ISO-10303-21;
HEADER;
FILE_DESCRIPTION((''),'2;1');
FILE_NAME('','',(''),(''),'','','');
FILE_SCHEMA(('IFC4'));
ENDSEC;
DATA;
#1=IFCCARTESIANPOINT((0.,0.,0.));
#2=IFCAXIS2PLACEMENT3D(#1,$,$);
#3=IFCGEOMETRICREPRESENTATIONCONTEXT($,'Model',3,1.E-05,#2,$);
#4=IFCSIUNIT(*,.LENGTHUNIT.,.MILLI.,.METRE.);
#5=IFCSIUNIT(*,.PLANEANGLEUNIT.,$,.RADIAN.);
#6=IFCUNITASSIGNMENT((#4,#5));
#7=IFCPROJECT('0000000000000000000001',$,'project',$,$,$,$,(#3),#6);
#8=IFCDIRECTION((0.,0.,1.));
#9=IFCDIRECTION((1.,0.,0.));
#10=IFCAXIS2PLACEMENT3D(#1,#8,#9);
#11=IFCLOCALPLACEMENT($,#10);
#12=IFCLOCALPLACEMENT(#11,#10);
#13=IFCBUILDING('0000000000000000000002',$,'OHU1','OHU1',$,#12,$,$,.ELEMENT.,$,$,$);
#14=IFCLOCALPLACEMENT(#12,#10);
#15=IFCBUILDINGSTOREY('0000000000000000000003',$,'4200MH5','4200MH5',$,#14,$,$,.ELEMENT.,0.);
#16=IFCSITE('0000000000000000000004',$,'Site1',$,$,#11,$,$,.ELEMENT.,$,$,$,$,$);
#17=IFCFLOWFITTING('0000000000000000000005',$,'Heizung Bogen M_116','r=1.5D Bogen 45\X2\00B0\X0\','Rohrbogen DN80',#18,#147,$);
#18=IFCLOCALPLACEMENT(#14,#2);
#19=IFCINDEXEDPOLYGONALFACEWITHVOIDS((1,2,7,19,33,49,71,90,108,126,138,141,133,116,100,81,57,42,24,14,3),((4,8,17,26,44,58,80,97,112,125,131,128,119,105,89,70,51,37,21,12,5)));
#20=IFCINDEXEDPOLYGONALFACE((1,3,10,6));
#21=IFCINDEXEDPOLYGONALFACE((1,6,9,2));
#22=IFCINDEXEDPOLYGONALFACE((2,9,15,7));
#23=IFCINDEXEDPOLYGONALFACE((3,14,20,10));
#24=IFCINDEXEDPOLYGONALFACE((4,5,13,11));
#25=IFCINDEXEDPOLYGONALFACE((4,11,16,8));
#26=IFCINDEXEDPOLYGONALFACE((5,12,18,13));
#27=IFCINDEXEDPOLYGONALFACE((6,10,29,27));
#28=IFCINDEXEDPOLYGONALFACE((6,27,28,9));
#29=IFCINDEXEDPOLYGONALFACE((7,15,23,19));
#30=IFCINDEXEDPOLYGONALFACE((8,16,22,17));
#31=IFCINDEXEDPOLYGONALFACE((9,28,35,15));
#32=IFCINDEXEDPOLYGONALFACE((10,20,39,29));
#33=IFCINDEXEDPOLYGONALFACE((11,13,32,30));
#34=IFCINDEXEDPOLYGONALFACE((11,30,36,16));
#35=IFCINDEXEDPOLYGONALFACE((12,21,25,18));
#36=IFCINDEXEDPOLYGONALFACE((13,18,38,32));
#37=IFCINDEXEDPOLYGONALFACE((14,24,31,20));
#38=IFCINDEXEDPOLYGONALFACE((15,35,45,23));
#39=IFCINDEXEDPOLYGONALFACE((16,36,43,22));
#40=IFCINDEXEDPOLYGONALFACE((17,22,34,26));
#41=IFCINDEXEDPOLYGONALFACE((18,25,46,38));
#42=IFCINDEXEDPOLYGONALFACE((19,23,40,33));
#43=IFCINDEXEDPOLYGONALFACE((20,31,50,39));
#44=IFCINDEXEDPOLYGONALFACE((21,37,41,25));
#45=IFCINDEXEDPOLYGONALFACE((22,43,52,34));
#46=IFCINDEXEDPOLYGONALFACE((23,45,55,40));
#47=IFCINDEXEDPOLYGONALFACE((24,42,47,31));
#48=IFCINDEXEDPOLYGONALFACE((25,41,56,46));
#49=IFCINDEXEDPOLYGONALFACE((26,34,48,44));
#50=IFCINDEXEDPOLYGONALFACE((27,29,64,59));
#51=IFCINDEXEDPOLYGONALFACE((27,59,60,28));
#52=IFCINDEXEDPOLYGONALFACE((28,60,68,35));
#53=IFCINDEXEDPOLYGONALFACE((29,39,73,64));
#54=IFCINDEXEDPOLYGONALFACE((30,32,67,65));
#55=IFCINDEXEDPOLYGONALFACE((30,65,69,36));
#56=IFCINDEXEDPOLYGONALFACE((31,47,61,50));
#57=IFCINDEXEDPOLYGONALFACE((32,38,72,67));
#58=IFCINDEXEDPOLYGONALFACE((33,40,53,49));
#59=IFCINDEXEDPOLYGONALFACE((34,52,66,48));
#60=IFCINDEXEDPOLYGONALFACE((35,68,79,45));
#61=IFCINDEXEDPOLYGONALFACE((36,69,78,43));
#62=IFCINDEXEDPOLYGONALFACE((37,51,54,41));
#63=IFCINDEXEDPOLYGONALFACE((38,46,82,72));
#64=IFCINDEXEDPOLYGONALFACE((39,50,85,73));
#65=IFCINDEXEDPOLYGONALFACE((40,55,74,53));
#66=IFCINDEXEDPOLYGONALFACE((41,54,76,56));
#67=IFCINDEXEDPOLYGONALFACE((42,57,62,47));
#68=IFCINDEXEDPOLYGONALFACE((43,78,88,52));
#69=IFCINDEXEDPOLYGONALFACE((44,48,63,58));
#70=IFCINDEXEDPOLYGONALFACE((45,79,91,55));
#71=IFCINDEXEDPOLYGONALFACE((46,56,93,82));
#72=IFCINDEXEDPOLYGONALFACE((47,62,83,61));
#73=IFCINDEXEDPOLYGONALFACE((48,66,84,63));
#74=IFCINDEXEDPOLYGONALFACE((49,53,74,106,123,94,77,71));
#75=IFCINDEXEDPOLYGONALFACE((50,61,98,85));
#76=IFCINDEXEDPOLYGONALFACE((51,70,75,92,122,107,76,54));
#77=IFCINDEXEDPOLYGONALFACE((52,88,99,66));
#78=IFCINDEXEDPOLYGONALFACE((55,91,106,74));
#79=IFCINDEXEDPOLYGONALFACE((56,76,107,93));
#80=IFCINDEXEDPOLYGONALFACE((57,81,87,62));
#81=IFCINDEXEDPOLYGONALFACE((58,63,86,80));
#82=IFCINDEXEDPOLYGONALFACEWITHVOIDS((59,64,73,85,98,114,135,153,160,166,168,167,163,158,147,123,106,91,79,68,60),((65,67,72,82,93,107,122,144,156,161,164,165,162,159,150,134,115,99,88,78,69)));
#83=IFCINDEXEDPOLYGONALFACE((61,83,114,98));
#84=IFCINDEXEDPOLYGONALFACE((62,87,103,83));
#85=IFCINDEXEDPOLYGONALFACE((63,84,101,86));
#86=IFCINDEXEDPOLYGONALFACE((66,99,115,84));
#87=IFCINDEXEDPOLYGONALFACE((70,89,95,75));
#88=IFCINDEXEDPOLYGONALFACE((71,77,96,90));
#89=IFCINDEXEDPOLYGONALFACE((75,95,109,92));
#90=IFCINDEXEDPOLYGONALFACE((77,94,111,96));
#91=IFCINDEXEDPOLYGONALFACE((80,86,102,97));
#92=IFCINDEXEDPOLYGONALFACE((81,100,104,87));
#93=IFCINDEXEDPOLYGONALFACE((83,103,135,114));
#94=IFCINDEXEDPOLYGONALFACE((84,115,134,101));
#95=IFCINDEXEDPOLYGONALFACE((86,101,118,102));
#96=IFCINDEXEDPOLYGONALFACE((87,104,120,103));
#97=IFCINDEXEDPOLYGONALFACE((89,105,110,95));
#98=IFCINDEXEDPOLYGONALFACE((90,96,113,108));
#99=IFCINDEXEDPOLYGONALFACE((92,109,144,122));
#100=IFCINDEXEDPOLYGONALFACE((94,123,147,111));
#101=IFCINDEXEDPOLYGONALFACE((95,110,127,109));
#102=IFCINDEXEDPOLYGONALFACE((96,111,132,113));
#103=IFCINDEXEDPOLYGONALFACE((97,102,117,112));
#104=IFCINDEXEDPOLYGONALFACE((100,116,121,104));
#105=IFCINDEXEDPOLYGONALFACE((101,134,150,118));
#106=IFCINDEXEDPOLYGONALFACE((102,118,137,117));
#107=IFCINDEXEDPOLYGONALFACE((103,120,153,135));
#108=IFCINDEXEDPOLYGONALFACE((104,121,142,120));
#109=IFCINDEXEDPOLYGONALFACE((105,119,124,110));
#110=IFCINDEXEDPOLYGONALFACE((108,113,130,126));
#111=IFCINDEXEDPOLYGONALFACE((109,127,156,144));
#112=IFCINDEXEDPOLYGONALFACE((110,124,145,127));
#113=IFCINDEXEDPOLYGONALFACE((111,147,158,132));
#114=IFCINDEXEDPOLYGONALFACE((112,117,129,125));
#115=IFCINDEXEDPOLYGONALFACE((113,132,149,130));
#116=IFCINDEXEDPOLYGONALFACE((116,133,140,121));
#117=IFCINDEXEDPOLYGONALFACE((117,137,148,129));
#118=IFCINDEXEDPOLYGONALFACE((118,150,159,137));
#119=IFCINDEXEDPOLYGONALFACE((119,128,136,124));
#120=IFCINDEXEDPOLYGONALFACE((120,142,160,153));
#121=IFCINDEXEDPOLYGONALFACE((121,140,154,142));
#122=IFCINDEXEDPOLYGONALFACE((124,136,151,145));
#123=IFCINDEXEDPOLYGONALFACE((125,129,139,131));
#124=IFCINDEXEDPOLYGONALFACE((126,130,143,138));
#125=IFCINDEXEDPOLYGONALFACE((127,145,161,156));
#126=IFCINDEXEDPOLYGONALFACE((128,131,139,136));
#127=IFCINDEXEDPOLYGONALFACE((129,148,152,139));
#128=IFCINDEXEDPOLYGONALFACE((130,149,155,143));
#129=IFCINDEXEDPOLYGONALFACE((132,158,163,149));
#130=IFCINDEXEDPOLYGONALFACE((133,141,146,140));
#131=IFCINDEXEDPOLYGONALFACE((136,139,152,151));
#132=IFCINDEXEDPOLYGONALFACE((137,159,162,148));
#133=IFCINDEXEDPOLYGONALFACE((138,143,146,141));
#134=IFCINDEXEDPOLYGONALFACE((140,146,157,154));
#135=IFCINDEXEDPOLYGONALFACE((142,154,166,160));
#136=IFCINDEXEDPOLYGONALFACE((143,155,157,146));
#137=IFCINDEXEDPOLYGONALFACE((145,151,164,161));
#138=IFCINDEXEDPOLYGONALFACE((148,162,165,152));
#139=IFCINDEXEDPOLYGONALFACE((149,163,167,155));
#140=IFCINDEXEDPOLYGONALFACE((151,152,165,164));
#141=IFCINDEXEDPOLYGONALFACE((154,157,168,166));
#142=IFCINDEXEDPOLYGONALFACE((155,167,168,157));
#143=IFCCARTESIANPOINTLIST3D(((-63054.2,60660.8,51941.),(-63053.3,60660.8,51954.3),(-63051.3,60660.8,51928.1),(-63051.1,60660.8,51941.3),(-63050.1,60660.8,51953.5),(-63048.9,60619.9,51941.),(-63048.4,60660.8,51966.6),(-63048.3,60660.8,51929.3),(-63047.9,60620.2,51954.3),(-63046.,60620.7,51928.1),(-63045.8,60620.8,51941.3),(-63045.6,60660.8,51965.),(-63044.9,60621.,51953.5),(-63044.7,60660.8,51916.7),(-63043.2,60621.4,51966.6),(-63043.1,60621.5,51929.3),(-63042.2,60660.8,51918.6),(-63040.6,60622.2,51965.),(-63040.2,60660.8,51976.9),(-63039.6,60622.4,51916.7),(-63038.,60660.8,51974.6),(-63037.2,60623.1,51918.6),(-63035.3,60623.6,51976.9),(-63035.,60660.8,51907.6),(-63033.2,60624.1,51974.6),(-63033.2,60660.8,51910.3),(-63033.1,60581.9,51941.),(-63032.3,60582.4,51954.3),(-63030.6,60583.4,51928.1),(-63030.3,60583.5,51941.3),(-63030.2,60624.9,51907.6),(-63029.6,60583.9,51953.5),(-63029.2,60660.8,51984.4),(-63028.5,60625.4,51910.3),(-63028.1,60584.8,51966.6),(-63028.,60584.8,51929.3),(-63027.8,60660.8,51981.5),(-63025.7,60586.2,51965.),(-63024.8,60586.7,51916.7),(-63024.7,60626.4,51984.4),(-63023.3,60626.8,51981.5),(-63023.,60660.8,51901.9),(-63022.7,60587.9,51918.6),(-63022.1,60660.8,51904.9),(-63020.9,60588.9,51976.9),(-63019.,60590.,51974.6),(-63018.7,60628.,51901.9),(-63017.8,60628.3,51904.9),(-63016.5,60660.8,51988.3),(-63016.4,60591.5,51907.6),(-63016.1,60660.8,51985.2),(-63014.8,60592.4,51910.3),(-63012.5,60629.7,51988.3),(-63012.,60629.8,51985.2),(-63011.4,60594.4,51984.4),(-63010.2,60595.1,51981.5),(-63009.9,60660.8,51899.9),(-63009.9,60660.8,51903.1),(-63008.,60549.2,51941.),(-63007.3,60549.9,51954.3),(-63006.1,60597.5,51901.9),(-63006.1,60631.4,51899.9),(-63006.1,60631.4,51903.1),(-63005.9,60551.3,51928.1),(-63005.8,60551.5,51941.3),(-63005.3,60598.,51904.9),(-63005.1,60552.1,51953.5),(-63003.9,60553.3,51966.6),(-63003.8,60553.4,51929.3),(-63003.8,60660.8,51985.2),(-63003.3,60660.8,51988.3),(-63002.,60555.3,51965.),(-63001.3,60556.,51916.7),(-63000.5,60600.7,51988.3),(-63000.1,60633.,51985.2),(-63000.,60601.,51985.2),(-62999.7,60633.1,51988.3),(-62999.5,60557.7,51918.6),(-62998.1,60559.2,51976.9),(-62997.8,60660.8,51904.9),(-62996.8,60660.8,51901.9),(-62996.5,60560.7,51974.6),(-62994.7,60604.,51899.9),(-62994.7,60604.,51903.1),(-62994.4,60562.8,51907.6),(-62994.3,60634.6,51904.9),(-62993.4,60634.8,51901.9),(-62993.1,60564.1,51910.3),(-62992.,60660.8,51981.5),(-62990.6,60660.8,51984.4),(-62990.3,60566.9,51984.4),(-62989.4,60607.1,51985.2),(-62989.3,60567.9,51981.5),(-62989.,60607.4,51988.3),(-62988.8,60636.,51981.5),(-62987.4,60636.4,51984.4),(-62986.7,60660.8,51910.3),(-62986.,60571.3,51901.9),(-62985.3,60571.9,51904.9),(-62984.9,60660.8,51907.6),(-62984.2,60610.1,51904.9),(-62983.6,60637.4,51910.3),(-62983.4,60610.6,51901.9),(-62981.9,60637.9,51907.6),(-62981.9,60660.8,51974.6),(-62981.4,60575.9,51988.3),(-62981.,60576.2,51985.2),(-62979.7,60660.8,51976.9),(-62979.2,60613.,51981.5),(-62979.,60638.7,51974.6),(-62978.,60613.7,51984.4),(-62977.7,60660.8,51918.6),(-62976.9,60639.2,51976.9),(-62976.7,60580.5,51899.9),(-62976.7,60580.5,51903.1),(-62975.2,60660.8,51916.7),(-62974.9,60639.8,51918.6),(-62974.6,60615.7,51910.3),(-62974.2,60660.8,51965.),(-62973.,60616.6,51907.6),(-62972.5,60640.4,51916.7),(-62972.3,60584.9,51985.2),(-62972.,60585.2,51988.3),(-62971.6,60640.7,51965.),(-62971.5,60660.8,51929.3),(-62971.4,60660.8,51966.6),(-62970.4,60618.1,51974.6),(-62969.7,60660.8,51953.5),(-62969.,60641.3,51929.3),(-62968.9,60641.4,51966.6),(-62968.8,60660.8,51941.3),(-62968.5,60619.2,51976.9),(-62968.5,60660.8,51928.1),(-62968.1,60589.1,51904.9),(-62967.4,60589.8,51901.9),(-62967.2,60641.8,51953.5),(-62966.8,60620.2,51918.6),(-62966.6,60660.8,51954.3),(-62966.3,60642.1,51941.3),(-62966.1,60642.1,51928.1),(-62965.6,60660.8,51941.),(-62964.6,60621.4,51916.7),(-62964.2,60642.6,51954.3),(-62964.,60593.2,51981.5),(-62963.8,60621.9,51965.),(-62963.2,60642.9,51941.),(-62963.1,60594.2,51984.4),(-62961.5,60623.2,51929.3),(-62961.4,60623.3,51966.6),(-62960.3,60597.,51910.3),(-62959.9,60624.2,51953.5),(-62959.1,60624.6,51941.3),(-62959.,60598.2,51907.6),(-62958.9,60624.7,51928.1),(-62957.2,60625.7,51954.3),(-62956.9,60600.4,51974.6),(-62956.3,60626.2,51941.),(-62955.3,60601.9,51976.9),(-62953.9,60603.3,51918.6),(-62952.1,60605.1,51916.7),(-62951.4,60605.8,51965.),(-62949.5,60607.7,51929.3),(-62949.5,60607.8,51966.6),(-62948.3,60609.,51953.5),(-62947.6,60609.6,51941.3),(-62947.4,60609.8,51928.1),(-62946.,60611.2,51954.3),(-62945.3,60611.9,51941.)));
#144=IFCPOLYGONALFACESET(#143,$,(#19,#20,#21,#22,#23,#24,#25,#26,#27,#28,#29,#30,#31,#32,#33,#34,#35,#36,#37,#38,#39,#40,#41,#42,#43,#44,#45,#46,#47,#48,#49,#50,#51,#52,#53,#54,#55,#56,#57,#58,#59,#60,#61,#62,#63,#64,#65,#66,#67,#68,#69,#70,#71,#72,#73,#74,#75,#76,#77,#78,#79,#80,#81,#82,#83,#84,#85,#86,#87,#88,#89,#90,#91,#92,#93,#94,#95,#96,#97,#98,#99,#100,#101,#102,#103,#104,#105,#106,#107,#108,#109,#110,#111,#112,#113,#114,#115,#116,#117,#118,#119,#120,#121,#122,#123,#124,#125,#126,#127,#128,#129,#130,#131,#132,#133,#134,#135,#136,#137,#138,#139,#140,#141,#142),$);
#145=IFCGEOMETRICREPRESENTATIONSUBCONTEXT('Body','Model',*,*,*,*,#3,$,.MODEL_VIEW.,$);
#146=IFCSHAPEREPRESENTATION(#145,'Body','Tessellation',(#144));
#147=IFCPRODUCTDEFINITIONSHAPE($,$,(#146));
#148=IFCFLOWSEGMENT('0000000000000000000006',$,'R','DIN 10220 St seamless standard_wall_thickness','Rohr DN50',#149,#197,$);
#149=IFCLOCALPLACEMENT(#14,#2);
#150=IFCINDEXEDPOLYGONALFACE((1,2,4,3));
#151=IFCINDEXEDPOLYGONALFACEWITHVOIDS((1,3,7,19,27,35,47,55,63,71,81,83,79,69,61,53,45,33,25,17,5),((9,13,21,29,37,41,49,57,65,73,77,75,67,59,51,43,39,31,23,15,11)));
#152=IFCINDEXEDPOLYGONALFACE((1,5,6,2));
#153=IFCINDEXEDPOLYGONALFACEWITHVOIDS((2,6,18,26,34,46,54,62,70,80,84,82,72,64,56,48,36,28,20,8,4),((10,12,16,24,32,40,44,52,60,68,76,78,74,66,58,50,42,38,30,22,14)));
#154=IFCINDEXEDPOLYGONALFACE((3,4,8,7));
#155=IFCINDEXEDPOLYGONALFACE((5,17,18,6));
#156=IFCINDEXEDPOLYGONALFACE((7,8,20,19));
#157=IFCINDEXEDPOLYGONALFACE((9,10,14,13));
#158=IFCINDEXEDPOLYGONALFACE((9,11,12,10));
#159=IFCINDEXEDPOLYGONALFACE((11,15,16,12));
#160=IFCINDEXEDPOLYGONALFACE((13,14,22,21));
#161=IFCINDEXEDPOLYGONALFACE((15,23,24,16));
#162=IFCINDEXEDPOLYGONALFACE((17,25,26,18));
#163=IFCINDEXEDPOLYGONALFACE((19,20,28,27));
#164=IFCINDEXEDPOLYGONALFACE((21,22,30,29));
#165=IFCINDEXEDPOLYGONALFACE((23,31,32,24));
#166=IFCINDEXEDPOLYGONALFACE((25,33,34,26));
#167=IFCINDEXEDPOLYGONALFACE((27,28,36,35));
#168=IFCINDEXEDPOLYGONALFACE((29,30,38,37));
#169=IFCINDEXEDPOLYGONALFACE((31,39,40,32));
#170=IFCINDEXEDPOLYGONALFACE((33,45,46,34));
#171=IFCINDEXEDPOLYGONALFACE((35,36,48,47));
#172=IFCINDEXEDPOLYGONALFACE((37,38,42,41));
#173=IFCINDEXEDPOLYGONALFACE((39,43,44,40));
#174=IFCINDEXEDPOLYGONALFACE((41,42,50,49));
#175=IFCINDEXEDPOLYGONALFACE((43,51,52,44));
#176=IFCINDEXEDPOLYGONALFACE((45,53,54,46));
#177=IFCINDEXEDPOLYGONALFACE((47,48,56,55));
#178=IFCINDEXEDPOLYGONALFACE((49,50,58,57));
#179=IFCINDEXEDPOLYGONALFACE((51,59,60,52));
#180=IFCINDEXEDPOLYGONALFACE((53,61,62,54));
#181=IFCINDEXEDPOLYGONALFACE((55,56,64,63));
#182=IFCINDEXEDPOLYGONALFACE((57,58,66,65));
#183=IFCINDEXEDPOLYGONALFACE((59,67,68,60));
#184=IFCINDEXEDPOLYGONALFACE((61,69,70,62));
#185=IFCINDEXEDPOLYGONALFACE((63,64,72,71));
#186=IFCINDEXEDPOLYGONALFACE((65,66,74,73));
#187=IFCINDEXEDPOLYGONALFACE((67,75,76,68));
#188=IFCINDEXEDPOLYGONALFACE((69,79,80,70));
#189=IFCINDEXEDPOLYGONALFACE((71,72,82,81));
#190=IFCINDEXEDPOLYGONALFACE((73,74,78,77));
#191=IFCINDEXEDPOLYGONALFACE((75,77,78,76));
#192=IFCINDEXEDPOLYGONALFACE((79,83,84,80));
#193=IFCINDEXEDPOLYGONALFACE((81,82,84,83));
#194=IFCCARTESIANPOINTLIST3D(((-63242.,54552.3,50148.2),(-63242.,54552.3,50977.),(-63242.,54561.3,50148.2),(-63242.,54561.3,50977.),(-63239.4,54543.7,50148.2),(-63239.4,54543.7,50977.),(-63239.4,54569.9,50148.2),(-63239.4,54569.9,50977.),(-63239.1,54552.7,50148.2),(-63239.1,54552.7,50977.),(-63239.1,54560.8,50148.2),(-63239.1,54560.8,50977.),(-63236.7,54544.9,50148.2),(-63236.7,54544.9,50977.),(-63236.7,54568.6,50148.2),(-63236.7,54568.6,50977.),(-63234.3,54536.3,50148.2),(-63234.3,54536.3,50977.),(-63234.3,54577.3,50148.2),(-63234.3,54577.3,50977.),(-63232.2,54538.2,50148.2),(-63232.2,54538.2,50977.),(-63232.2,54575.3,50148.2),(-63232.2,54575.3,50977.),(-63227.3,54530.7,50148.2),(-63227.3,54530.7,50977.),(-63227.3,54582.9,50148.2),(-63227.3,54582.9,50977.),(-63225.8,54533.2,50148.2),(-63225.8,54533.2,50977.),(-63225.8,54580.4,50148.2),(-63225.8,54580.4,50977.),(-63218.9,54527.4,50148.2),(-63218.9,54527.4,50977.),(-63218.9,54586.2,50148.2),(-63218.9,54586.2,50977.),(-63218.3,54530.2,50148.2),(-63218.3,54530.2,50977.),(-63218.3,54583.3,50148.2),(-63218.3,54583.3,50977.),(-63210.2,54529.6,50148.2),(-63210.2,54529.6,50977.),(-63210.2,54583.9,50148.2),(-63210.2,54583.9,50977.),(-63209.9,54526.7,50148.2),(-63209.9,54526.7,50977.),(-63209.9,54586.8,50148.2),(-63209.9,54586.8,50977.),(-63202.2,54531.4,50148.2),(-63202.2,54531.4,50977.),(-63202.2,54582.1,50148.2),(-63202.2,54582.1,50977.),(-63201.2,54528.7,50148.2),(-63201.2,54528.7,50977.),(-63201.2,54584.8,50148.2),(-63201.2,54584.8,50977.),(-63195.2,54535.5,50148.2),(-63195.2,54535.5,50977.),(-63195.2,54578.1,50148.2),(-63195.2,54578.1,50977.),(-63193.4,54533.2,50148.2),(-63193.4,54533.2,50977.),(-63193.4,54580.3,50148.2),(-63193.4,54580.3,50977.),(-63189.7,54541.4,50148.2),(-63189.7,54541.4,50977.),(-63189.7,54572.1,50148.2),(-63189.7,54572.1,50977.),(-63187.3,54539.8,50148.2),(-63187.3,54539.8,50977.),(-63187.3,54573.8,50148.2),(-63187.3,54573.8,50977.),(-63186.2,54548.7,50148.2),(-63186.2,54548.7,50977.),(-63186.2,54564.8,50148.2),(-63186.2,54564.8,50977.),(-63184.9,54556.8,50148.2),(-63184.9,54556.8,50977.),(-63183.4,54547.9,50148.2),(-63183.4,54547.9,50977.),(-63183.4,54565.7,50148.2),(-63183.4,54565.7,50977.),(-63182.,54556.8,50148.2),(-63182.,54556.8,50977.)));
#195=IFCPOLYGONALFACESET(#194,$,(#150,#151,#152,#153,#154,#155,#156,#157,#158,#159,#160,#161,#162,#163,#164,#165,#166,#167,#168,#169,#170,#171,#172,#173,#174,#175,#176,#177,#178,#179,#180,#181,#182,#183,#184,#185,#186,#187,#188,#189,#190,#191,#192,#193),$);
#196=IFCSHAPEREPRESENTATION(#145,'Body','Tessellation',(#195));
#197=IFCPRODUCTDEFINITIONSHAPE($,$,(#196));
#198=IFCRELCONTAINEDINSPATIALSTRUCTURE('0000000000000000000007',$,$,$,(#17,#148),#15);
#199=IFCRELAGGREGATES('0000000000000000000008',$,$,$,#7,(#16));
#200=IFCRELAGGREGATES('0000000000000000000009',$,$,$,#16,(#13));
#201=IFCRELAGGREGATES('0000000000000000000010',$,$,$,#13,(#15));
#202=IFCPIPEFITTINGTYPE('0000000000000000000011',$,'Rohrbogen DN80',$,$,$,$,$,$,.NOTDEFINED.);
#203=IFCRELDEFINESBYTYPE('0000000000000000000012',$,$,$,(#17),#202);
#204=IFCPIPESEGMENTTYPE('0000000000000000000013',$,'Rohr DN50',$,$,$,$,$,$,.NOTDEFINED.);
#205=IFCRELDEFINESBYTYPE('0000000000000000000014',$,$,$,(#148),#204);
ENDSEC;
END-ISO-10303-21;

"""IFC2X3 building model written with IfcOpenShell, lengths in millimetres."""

from ifc_helpers import new_model, entity, si_unit, frame, origin, origin_with_axes, origin_2d_with_axis, place, context, subcontext, project, spatial, hollow_circle, extrude, type_object, element, save


model = new_model("IFC2X3")

# Units and contexts
model_context = context("Model", 3, precision=1e-05, world=origin())
body_context = subcontext(model_context, "Body", "Model", "MODEL_VIEW")
ifc_project = project(units=[si_unit("LENGTHUNIT", "METRE", prefix="MILLI"), si_unit("PLANEANGLEUNIT", "RADIAN")], contexts=[model_context])

# Site, building, storey
site_placement = place(None, origin_with_axes())
site = spatial("IfcSite", under=ifc_project, at=site_placement, Name="Site1", CompositionType="ELEMENT")
building_placement = place(site_placement, origin_with_axes())
building = spatial("IfcBuilding", under=site, at=building_placement, Name="OHU1", Description="OHU1", CompositionType="ELEMENT")
storey_placement = place(building_placement, origin_with_axes())
storey = spatial("IfcBuildingStorey", under=building, at=storey_placement, Name="4200MH5", Description="4200MH5", CompositionType="ELEMENT", Elevation=0.0)

# Flow fitting
pipe_fitting_type_1 = type_object("IfcPipeFittingType", Name="Rohrbogen DN80", PredefinedType="NOTDEFINED")
flow_fitting_1_placement = place(storey_placement, frame((-63009.9, 60580.7, 51944.4), z_axis=(0.0, 0.0, 1.0), x_axis=(1.0, 0.0, 0.0)))
element("IfcFlowFitting", 1, at=flow_fitting_1_placement, inside=storey, type_object=pipe_fitting_type_1, Name="Heizung Bogen M_116", Description="r=1.5D Bogen 45°", ObjectType="Rohrbogen DN80", context=body_context, shape_type="SweptSolid", body=[
    entity("IfcRevolvedAreaSolid", entity("IfcCircleHollowProfileDef", "AREA", None, entity("IfcAxis2Placement2D", entity("IfcCartesianPoint", [0.0, 0.0]), entity("IfcDirection", [1.0, 0.0])), 44.5, 3.2), entity("IfcAxis2Placement3D", entity("IfcCartesianPoint", [0.0, 80.1, 0.0]), entity("IfcDirection", [-0.000003, -1.0, 0.0]), entity("IfcDirection", [0.0, 0.0, -1.0])), entity("IfcAxis1Placement", entity("IfcCartesianPoint", [0.0, 113.5, 0.0]), entity("IfcDirection", [-1.0, 0.0, 0.0])), 0.785398),
])

# Flow segment
pipe_segment_type_1 = type_object("IfcPipeSegmentType", Name="Rohr DN50", PredefinedType="NOTDEFINED")
flow_segment_1_placement = place(storey_placement, frame((-63212.2, 54556.8, 50562.6), z_axis=(0.0, 0.0, 1.0), x_axis=(1.0, 0.0, 0.0)))
element("IfcFlowSegment", 2, at=flow_segment_1_placement, inside=storey, type_object=pipe_segment_type_1, Name="R", Description="DIN 10220 St seamless standard_wall_thickness", ObjectType="Rohr DN50", context=body_context, shape_type="SweptSolid", body=[
    extrude(hollow_circle(Radius=30.1, WallThickness=2.9, at=origin_2d_with_axis()), frame((0.0, 0.0, 414.4), z_axis=(0.0, 0.0, -1.0), x_axis=(1.0, 0.0, 0.0)), (0.0, 0.0, 1.0), 828.9),
])

save(model, "model.ifc")
